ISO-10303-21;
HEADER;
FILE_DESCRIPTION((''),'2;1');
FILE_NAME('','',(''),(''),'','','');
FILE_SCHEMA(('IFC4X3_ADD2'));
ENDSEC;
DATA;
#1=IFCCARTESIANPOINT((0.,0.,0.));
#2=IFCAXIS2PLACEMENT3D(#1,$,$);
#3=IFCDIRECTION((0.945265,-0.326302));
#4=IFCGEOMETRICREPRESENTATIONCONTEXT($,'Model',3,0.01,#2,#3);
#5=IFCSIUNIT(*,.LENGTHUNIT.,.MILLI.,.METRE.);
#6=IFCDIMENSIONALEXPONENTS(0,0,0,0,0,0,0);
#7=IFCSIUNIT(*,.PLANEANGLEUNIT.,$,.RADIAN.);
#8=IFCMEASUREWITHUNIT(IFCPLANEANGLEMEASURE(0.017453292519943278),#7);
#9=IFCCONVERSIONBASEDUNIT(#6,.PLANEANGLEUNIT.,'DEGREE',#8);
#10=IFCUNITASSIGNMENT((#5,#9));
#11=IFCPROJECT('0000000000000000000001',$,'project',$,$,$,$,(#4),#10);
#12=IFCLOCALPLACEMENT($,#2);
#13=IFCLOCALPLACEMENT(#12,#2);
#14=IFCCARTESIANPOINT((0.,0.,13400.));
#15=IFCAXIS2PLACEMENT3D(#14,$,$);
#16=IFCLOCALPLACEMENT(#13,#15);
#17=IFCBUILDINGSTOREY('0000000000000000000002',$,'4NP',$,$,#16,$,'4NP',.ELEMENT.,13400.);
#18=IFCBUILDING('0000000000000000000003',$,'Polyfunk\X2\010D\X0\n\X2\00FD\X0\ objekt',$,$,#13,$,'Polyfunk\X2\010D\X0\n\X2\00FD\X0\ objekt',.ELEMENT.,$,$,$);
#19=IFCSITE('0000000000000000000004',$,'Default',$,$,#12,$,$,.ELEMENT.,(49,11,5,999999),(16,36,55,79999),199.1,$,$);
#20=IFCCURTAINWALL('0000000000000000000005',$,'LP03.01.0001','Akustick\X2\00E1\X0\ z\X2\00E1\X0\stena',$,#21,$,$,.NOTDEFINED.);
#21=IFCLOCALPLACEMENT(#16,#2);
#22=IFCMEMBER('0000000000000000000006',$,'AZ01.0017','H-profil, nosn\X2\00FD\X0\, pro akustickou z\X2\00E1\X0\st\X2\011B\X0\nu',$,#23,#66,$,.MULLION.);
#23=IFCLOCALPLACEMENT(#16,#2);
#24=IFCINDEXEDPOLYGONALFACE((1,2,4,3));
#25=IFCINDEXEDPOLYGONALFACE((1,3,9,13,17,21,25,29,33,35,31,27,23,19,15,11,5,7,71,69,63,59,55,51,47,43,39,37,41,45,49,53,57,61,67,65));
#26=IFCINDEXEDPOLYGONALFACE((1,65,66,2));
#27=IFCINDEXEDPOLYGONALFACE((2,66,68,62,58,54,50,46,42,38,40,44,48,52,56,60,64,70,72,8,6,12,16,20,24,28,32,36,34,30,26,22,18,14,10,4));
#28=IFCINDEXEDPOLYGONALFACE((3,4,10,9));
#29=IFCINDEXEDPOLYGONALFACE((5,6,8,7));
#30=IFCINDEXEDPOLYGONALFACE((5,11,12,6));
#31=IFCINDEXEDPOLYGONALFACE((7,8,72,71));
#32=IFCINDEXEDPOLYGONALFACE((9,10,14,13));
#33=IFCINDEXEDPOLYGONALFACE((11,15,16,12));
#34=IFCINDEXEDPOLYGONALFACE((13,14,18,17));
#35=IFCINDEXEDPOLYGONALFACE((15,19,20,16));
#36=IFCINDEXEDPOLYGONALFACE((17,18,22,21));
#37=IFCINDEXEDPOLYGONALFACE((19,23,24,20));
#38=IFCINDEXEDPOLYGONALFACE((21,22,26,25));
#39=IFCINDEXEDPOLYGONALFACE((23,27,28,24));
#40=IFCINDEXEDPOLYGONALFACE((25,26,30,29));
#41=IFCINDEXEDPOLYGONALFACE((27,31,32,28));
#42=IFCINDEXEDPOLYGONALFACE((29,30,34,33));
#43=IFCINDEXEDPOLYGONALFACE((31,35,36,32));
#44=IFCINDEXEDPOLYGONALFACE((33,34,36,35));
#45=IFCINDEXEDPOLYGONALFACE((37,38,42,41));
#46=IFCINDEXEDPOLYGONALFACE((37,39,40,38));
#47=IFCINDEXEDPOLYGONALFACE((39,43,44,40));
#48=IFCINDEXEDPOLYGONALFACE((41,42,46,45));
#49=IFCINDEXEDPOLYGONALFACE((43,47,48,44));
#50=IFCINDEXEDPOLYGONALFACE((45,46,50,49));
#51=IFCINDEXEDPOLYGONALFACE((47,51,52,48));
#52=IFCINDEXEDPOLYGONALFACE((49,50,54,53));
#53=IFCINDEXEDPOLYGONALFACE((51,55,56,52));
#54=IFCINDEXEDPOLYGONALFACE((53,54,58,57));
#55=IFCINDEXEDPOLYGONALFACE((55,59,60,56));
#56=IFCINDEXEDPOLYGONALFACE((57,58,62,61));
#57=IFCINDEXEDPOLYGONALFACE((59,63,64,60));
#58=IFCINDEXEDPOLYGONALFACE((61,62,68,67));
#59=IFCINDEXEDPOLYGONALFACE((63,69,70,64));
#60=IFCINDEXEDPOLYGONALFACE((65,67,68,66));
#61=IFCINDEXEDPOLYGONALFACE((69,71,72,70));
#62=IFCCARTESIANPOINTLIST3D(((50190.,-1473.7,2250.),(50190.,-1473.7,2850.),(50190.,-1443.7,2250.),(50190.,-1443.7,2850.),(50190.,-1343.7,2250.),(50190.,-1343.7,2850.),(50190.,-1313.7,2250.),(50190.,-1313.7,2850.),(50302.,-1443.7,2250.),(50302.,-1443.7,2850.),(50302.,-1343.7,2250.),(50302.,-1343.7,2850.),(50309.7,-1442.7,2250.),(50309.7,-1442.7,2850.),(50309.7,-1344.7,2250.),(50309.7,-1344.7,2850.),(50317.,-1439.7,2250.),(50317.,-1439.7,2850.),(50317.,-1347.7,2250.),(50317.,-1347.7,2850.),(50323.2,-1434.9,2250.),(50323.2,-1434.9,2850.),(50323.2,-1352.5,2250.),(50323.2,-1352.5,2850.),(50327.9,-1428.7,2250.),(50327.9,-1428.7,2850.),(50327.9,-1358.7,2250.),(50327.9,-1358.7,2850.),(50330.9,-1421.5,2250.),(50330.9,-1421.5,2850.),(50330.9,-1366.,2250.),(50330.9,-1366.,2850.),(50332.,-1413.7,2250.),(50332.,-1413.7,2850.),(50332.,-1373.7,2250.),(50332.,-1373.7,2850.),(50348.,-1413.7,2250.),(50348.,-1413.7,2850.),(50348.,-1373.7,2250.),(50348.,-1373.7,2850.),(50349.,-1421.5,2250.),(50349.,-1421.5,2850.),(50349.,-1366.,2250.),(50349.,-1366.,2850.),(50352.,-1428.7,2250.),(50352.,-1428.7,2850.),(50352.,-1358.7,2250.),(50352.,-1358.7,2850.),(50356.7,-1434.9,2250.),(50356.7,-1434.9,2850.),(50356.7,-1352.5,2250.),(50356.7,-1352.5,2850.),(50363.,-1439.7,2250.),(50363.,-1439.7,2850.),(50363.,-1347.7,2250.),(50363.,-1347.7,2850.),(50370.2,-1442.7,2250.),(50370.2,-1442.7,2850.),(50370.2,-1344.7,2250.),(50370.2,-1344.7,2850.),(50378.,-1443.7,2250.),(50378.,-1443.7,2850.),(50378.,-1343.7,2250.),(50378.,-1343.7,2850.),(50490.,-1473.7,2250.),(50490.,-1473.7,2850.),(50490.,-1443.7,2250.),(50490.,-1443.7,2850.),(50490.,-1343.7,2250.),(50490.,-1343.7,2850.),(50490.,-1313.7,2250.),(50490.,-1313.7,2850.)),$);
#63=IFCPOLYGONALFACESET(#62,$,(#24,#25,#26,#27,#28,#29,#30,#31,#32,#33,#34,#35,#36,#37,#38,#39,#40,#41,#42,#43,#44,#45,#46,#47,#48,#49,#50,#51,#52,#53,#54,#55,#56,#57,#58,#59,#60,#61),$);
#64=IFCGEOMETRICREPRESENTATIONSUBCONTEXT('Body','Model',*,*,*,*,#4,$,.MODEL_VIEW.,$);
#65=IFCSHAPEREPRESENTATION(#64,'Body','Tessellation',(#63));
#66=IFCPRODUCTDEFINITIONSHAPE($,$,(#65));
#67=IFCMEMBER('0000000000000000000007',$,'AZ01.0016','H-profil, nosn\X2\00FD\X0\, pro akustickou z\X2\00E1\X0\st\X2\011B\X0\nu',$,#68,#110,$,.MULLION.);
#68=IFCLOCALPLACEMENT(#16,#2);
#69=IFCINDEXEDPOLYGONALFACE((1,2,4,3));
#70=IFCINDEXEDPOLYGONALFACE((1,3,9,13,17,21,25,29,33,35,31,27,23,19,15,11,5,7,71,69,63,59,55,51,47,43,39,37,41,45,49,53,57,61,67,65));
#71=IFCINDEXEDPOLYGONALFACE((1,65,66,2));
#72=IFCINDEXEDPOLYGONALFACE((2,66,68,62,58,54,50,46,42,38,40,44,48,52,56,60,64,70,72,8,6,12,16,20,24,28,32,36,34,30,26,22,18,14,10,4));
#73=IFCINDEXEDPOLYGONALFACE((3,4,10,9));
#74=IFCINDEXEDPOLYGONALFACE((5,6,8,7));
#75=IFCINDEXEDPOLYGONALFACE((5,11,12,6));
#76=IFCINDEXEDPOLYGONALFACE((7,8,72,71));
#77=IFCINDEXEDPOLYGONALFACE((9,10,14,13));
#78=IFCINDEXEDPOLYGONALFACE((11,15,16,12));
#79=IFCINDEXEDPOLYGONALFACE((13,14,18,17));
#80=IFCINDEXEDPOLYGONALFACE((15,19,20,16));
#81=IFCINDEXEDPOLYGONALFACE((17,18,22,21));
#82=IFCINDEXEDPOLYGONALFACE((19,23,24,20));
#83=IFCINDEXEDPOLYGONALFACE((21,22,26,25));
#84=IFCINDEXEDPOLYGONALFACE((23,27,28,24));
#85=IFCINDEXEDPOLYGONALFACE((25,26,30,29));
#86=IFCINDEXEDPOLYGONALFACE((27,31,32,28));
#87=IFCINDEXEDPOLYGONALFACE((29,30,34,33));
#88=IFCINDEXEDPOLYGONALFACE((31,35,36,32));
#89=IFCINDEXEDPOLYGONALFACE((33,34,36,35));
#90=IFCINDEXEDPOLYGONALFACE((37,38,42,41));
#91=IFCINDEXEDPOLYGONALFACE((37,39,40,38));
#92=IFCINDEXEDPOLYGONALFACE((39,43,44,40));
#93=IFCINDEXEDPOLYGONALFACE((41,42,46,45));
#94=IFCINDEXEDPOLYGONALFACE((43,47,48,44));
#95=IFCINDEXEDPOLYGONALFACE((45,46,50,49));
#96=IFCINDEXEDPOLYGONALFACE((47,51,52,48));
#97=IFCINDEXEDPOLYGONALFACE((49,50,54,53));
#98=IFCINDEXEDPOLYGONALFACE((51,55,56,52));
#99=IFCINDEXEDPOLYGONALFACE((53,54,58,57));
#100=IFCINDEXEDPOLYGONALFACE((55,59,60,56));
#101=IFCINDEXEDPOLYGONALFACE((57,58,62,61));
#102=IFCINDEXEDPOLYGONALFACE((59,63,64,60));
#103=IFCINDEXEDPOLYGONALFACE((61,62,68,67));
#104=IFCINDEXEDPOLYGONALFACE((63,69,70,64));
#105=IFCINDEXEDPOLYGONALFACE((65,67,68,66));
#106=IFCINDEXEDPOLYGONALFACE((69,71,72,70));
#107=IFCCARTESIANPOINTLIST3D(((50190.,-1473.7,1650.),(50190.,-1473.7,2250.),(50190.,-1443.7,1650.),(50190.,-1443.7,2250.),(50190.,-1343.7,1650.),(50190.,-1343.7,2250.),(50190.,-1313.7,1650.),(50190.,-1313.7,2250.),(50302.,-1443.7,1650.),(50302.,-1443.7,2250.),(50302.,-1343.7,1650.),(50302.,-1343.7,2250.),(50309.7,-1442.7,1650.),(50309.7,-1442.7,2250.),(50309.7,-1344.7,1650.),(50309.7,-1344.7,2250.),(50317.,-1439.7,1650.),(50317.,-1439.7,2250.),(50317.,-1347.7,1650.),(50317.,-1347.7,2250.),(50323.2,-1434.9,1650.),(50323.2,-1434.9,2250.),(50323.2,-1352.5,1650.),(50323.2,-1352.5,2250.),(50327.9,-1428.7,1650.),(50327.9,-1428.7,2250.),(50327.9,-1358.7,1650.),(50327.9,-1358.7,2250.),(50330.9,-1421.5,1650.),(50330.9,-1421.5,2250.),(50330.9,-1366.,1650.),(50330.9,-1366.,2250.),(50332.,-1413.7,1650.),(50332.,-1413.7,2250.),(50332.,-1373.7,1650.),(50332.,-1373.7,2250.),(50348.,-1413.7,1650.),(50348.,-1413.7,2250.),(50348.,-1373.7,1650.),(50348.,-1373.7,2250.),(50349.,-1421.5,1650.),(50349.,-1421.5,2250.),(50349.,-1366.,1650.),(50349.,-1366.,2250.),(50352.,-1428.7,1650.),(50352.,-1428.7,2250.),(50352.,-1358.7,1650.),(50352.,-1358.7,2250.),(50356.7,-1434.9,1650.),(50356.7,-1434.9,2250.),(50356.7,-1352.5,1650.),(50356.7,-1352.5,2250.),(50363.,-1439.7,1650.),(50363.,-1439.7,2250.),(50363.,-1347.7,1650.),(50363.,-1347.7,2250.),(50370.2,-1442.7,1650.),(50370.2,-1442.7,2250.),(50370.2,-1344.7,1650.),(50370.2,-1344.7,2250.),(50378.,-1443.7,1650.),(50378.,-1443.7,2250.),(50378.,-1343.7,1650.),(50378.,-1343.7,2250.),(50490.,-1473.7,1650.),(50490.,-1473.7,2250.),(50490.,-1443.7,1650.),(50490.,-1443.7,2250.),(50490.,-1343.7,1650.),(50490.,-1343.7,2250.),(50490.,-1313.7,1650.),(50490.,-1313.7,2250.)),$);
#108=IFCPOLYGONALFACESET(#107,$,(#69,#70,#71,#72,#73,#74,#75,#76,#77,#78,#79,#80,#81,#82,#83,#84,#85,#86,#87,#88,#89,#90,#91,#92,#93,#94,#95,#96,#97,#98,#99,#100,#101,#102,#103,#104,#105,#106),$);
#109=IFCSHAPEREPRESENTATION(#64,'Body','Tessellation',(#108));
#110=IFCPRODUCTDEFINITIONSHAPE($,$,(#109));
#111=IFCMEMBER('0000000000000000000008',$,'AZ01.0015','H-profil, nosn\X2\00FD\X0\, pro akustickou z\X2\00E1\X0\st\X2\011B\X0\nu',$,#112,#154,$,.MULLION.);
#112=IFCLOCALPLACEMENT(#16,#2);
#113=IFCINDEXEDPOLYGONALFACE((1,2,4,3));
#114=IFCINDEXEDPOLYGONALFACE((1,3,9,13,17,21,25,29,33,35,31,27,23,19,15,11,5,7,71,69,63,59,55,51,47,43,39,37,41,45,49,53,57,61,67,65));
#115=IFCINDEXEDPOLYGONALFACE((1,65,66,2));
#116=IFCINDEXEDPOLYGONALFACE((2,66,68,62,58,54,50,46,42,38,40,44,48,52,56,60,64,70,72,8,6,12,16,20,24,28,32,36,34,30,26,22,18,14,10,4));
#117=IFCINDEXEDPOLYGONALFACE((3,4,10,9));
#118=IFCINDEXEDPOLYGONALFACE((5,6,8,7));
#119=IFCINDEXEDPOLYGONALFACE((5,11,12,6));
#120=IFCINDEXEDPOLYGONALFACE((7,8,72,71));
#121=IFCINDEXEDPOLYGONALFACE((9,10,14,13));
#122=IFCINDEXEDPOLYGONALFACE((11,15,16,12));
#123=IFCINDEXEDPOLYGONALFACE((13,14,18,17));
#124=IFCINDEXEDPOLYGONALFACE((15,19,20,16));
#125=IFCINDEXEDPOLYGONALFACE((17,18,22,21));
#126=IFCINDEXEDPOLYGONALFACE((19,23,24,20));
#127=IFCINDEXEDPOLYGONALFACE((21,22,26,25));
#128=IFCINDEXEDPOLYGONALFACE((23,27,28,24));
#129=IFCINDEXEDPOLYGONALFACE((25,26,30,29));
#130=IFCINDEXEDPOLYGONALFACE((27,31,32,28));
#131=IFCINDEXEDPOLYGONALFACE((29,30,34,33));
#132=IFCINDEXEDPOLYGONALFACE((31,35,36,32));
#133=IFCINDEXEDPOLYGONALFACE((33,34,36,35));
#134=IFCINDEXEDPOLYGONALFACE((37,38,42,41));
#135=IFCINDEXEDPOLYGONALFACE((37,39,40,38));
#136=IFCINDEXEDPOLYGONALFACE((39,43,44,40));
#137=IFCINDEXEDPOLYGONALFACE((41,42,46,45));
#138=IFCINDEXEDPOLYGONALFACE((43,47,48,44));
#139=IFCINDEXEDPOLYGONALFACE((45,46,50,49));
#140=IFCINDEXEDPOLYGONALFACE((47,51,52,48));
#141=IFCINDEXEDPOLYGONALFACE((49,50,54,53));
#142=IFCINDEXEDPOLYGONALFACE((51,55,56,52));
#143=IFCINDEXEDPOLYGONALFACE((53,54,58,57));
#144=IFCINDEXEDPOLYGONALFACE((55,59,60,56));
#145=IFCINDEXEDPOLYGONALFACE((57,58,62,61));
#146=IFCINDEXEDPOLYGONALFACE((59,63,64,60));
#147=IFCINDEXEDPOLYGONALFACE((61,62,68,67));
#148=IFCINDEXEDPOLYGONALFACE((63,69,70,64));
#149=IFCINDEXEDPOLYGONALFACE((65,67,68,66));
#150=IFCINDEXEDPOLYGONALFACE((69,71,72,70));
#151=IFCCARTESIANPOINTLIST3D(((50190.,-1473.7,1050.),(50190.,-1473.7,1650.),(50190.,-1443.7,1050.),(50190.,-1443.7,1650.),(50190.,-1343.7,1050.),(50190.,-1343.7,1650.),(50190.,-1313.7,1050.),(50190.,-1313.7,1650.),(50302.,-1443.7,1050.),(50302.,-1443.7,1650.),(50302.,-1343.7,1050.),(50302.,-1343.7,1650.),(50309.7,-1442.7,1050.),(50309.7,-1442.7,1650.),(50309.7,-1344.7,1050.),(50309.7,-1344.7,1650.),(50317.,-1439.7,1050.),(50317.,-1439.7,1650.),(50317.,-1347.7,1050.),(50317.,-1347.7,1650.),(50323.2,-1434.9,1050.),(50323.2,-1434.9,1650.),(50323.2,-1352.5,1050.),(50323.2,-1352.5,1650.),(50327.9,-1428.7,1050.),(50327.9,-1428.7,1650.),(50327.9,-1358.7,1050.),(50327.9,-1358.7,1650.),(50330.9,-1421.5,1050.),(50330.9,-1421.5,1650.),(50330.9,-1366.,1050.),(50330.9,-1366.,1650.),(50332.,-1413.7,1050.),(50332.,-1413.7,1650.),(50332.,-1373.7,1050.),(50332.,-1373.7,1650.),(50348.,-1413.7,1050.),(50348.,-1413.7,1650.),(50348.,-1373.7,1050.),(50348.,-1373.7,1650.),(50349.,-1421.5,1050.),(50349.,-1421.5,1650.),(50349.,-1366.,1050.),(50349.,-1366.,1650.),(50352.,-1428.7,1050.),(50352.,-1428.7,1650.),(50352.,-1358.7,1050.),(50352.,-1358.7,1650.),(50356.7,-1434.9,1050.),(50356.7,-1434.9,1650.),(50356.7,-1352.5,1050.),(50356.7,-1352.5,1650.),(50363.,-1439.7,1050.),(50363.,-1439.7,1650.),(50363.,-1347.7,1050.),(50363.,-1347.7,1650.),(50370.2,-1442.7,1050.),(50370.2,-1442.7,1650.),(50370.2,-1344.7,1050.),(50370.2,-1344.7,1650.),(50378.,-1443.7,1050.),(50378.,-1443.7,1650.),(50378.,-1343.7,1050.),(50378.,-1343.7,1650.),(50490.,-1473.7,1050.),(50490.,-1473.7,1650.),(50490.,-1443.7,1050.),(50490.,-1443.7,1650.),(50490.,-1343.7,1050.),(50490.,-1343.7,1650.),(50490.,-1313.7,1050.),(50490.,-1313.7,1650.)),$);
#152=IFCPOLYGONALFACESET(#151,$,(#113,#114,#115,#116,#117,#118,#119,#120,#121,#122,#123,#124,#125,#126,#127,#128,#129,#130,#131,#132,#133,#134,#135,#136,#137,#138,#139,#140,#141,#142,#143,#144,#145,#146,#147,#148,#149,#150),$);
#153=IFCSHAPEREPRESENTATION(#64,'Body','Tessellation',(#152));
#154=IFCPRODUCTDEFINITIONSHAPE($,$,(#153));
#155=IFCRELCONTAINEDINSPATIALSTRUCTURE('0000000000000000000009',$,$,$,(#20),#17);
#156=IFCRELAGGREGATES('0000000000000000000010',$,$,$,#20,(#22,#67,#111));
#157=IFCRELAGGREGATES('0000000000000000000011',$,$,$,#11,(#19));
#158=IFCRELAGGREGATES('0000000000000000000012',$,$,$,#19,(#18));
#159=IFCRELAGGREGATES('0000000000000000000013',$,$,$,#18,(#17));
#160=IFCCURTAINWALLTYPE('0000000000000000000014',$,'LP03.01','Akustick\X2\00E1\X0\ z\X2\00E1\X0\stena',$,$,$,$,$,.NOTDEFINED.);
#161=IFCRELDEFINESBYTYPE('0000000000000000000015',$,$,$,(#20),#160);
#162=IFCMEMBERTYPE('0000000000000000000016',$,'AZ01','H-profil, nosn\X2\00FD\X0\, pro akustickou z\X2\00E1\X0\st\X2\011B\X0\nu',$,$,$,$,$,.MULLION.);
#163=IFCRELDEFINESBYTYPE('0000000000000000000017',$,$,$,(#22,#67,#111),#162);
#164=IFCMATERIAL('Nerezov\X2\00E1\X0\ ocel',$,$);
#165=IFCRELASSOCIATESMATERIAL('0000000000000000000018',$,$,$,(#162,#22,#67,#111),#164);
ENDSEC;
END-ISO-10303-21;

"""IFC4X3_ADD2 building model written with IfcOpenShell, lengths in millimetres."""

from ifc_helpers import new_model, entity, si_unit, converted_unit, direction, frame, frame_2d, origin, place, context, subcontext, project, spatial, polyline, circle_curve, parameter, trimmed, segment, composite_curve, outline, extrude, source, transform, mapped, material, material_profile, profile_set, profile_usage, type_object, element, aggregate, save


model = new_model("IFC4X3_ADD2")

# Units and contexts
model_context = context("Model", 3, precision=0.01, world=origin(), true_north=direction((0.945265, -0.326302)))
body_context = subcontext(model_context, "Body", "Model", "MODEL_VIEW")
ifc_project = project(units=[si_unit("LENGTHUNIT", "METRE", prefix="MILLI"), converted_unit("PLANEANGLEUNIT", "DEGREE", entity("IfcPlaneAngleMeasure", 0.017453292519943278), si_unit("PLANEANGLEUNIT", "RADIAN"), dimensions=[0, 0, 0, 0, 0, 0, 0])], contexts=[model_context])

# Site, building, storey
site_placement = place(None, origin())
site = spatial("IfcSite", under=ifc_project, at=site_placement, Name="Default", CompositionType="ELEMENT", RefLatitude=(49, 11, 5, 999999), RefLongitude=(16, 36, 55, 79999), RefElevation=199.1)
building_placement = place(site_placement, origin())
building = spatial("IfcBuilding", under=site, at=building_placement, Name="Polyfunkčný objekt", LongName="Polyfunkčný objekt", CompositionType="ELEMENT")
storey_placement = place(building_placement, frame((0.0, 0.0, 13400.0)))
storey = spatial("IfcBuildingStorey", under=building, at=storey_placement, Name="4NP", LongName="4NP", CompositionType="ELEMENT", Elevation=13400.0)

# Curtain wall, members
curtain_wall_type = type_object("IfcCurtainWallType", Name="LP03.01", Description="Akustická zástena", PredefinedType="NOTDEFINED")
ifc_material_1 = material(Name="Nerezová ocel")
ifc_material_profile = material_profile(ifc_material_1, outline(composite_curve([segment(polyline([(50.0, -150.0), (80.0, -150.0)]), True, "CONTINUOUS"), segment(polyline([(80.0, -150.0), (80.0, 150.0)]), True, "CONTINUOUS"), segment(polyline([(80.0, 150.0), (50.0, 150.0)]), True, "CONTINUOUS"), segment(polyline([(50.0, 150.0), (50.0, 38.0)]), True, "CONTINUOUS"), segment(trimmed(circle_curve(frame_2d((20.0, 38.0), x_axis=(0.0, 1.0)), 30.0), [parameter(180.0)], [parameter(270.0)], True, "PARAMETER"), False, "CONTINUOUS"), segment(polyline([(20.0, 8.0), (-20.0, 8.0)]), True, "CONTINUOUS"), segment(trimmed(circle_curve(frame_2d((-20.0, 38.0), x_axis=(0.0, 1.0)), 30.0), [parameter(90.0)], [parameter(180.0)], True, "PARAMETER"), False, "CONTINUOUS"), segment(polyline([(-50.0, 38.0), (-50.0, 150.0)]), True, "CONTINUOUS"), segment(polyline([(-50.0, 150.0), (-80.0, 150.0)]), True, "CONTINUOUS"), segment(polyline([(-80.0, 150.0), (-80.0, -150.0)]), True, "CONTINUOUS"), segment(polyline([(-80.0, -150.0), (-50.0, -150.0)]), True, "CONTINUOUS"), segment(polyline([(-50.0, -150.0), (-50.0, -38.0)]), True, "CONTINUOUS"), segment(trimmed(circle_curve(frame_2d((-20.0, -38.0), x_axis=(0.0, 1.0)), 30.0), [parameter(0.0)], [parameter(90.0)], True, "PARAMETER"), False, "CONTINUOUS"), segment(polyline([(-20.0, -8.0), (20.0, -8.0)]), True, "CONTINUOUS"), segment(trimmed(circle_curve(frame_2d((20.0, -38.0), x_axis=(0.0, 1.0)), 30.0), [parameter(270.0)], [parameter(0.0)], True, "PARAMETER"), False, "CONTINUOUS"), segment(polyline([(50.0, -38.0), (50.0, -150.0)]), True, "CONTINUOUS")], self_intersect=False)), Name="Profil zástena")
ifc_profile_set = profile_set([ifc_material_profile], Name="Profil zástena")
ifc_profile_usage = profile_usage(ifc_profile_set)
member_type = type_object("IfcMemberType", Name="AZ01", Description="H-profil, nosný, pro akustickou zástěnu", PredefinedType="MULLION", material=ifc_profile_set)
shared_shape_1 = source(origin(), body_context, "Body", "SweptSolid", [
    extrude(outline(composite_curve([segment(polyline([(-150.0, -50.0), (-150.0, -80.0)]), True, "CONTINUOUS"), segment(polyline([(-150.0, -80.0), (150.0, -80.0)]), True, "CONTINUOUS"), segment(polyline([(150.0, -80.0), (150.0, -50.0)]), True, "CONTINUOUS"), segment(polyline([(150.0, -50.0), (38.0, -50.0)]), True, "CONTINUOUS"), segment(trimmed(circle_curve(frame_2d((38.0, -20.0), x_axis=(1.0, 0.0)), 30.0), [parameter(180.0)], [parameter(270.0)], True, "PARAMETER"), False, "CONTINUOUS"), segment(polyline([(8.0, -20.0), (8.0, 20.0)]), True, "CONTINUOUS"), segment(trimmed(circle_curve(frame_2d((38.0, 20.0), x_axis=(1.0, 0.0)), 30.0), [parameter(90.0)], [parameter(180.0)], True, "PARAMETER"), False, "CONTINUOUS"), segment(polyline([(38.0, 50.0), (150.0, 50.0)]), True, "CONTINUOUS"), segment(polyline([(150.0, 50.0), (150.0, 80.0)]), True, "CONTINUOUS"), segment(polyline([(150.0, 80.0), (-150.0, 80.0)]), True, "CONTINUOUS"), segment(polyline([(-150.0, 80.0), (-150.0, 50.0)]), True, "CONTINUOUS"), segment(polyline([(-150.0, 50.0), (-38.0, 50.0)]), True, "CONTINUOUS"), segment(trimmed(circle_curve(frame_2d((-38.0, 20.0), x_axis=(1.0, 0.0)), 30.0), [parameter(0.0)], [parameter(90.0)], True, "PARAMETER"), False, "CONTINUOUS"), segment(polyline([(-8.0, 20.0), (-8.0, -20.0)]), True, "CONTINUOUS"), segment(trimmed(circle_curve(frame_2d((-38.0, -20.0), x_axis=(1.0, 0.0)), 30.0), [parameter(270.0)], [parameter(0.0)], True, "PARAMETER"), False, "CONTINUOUS"), segment(polyline([(-38.0, -50.0), (-150.0, -50.0)]), True, "CONTINUOUS")], self_intersect=False)), frame((-150.0, 0.0, -600.0), z_axis=(0.0, 0.0, -1.0), x_axis=(-1.0, 0.0, 0.0)), (0.0, 0.0, -1.0), 600.0),
])
curtain_wall_1_placement = place(storey_placement, frame((0.0, 0.0, -13400.0)))
curtain_wall_1 = element("IfcCurtainWall", 1, at=curtain_wall_1_placement, inside=storey, type_object=curtain_wall_type, Name="LP03.01.0001", Description="Akustická zástena", PredefinedType="NOTDEFINED")
member_1_placement = place(curtain_wall_1_placement, frame((50190.0, -1393.7, 16250.0), z_axis=(0.0, 0.0, 1.0), x_axis=(-1.0, 0.0, 0.0)))
member_1 = element("IfcMember", 2, at=member_1_placement, type_object=member_type, material=ifc_profile_usage, Name="AZ01.0017", Description="H-profil, nosný, pro akustickou zástěnu", PredefinedType="MULLION", context=body_context, shape_type="MappedRepresentation", body=[
    mapped(shared_shape_1, transform((0.0, 0.0, 0.0), scale=1.0)),
])
member_2_placement = place(curtain_wall_1_placement, frame((50190.0, -1393.7, 15650.0), z_axis=(0.0, 0.0, 1.0), x_axis=(-1.0, 0.0, 0.0)))
member_2 = element("IfcMember", 3, at=member_2_placement, type_object=member_type, material=ifc_profile_usage, Name="AZ01.0016", Description="H-profil, nosný, pro akustickou zástěnu", PredefinedType="MULLION", context=body_context, shape_type="MappedRepresentation", body=[
    mapped(shared_shape_1, transform((0.0, 0.0, 0.0), scale=1.0)),
])
member_3_placement = place(curtain_wall_1_placement, frame((50190.0, -1393.7, 15050.0), z_axis=(0.0, 0.0, 1.0), x_axis=(-1.0, 0.0, 0.0)))
member_3 = element("IfcMember", 4, at=member_3_placement, type_object=member_type, material=ifc_profile_usage, Name="AZ01.0015", Description="H-profil, nosný, pro akustickou zástěnu", PredefinedType="MULLION", context=body_context, shape_type="MappedRepresentation", body=[
    mapped(shared_shape_1, transform((0.0, 0.0, 0.0), scale=1.0)),
])

aggregate(curtain_wall_1, [member_1, member_2, member_3])

save(model, "model.ifc")
